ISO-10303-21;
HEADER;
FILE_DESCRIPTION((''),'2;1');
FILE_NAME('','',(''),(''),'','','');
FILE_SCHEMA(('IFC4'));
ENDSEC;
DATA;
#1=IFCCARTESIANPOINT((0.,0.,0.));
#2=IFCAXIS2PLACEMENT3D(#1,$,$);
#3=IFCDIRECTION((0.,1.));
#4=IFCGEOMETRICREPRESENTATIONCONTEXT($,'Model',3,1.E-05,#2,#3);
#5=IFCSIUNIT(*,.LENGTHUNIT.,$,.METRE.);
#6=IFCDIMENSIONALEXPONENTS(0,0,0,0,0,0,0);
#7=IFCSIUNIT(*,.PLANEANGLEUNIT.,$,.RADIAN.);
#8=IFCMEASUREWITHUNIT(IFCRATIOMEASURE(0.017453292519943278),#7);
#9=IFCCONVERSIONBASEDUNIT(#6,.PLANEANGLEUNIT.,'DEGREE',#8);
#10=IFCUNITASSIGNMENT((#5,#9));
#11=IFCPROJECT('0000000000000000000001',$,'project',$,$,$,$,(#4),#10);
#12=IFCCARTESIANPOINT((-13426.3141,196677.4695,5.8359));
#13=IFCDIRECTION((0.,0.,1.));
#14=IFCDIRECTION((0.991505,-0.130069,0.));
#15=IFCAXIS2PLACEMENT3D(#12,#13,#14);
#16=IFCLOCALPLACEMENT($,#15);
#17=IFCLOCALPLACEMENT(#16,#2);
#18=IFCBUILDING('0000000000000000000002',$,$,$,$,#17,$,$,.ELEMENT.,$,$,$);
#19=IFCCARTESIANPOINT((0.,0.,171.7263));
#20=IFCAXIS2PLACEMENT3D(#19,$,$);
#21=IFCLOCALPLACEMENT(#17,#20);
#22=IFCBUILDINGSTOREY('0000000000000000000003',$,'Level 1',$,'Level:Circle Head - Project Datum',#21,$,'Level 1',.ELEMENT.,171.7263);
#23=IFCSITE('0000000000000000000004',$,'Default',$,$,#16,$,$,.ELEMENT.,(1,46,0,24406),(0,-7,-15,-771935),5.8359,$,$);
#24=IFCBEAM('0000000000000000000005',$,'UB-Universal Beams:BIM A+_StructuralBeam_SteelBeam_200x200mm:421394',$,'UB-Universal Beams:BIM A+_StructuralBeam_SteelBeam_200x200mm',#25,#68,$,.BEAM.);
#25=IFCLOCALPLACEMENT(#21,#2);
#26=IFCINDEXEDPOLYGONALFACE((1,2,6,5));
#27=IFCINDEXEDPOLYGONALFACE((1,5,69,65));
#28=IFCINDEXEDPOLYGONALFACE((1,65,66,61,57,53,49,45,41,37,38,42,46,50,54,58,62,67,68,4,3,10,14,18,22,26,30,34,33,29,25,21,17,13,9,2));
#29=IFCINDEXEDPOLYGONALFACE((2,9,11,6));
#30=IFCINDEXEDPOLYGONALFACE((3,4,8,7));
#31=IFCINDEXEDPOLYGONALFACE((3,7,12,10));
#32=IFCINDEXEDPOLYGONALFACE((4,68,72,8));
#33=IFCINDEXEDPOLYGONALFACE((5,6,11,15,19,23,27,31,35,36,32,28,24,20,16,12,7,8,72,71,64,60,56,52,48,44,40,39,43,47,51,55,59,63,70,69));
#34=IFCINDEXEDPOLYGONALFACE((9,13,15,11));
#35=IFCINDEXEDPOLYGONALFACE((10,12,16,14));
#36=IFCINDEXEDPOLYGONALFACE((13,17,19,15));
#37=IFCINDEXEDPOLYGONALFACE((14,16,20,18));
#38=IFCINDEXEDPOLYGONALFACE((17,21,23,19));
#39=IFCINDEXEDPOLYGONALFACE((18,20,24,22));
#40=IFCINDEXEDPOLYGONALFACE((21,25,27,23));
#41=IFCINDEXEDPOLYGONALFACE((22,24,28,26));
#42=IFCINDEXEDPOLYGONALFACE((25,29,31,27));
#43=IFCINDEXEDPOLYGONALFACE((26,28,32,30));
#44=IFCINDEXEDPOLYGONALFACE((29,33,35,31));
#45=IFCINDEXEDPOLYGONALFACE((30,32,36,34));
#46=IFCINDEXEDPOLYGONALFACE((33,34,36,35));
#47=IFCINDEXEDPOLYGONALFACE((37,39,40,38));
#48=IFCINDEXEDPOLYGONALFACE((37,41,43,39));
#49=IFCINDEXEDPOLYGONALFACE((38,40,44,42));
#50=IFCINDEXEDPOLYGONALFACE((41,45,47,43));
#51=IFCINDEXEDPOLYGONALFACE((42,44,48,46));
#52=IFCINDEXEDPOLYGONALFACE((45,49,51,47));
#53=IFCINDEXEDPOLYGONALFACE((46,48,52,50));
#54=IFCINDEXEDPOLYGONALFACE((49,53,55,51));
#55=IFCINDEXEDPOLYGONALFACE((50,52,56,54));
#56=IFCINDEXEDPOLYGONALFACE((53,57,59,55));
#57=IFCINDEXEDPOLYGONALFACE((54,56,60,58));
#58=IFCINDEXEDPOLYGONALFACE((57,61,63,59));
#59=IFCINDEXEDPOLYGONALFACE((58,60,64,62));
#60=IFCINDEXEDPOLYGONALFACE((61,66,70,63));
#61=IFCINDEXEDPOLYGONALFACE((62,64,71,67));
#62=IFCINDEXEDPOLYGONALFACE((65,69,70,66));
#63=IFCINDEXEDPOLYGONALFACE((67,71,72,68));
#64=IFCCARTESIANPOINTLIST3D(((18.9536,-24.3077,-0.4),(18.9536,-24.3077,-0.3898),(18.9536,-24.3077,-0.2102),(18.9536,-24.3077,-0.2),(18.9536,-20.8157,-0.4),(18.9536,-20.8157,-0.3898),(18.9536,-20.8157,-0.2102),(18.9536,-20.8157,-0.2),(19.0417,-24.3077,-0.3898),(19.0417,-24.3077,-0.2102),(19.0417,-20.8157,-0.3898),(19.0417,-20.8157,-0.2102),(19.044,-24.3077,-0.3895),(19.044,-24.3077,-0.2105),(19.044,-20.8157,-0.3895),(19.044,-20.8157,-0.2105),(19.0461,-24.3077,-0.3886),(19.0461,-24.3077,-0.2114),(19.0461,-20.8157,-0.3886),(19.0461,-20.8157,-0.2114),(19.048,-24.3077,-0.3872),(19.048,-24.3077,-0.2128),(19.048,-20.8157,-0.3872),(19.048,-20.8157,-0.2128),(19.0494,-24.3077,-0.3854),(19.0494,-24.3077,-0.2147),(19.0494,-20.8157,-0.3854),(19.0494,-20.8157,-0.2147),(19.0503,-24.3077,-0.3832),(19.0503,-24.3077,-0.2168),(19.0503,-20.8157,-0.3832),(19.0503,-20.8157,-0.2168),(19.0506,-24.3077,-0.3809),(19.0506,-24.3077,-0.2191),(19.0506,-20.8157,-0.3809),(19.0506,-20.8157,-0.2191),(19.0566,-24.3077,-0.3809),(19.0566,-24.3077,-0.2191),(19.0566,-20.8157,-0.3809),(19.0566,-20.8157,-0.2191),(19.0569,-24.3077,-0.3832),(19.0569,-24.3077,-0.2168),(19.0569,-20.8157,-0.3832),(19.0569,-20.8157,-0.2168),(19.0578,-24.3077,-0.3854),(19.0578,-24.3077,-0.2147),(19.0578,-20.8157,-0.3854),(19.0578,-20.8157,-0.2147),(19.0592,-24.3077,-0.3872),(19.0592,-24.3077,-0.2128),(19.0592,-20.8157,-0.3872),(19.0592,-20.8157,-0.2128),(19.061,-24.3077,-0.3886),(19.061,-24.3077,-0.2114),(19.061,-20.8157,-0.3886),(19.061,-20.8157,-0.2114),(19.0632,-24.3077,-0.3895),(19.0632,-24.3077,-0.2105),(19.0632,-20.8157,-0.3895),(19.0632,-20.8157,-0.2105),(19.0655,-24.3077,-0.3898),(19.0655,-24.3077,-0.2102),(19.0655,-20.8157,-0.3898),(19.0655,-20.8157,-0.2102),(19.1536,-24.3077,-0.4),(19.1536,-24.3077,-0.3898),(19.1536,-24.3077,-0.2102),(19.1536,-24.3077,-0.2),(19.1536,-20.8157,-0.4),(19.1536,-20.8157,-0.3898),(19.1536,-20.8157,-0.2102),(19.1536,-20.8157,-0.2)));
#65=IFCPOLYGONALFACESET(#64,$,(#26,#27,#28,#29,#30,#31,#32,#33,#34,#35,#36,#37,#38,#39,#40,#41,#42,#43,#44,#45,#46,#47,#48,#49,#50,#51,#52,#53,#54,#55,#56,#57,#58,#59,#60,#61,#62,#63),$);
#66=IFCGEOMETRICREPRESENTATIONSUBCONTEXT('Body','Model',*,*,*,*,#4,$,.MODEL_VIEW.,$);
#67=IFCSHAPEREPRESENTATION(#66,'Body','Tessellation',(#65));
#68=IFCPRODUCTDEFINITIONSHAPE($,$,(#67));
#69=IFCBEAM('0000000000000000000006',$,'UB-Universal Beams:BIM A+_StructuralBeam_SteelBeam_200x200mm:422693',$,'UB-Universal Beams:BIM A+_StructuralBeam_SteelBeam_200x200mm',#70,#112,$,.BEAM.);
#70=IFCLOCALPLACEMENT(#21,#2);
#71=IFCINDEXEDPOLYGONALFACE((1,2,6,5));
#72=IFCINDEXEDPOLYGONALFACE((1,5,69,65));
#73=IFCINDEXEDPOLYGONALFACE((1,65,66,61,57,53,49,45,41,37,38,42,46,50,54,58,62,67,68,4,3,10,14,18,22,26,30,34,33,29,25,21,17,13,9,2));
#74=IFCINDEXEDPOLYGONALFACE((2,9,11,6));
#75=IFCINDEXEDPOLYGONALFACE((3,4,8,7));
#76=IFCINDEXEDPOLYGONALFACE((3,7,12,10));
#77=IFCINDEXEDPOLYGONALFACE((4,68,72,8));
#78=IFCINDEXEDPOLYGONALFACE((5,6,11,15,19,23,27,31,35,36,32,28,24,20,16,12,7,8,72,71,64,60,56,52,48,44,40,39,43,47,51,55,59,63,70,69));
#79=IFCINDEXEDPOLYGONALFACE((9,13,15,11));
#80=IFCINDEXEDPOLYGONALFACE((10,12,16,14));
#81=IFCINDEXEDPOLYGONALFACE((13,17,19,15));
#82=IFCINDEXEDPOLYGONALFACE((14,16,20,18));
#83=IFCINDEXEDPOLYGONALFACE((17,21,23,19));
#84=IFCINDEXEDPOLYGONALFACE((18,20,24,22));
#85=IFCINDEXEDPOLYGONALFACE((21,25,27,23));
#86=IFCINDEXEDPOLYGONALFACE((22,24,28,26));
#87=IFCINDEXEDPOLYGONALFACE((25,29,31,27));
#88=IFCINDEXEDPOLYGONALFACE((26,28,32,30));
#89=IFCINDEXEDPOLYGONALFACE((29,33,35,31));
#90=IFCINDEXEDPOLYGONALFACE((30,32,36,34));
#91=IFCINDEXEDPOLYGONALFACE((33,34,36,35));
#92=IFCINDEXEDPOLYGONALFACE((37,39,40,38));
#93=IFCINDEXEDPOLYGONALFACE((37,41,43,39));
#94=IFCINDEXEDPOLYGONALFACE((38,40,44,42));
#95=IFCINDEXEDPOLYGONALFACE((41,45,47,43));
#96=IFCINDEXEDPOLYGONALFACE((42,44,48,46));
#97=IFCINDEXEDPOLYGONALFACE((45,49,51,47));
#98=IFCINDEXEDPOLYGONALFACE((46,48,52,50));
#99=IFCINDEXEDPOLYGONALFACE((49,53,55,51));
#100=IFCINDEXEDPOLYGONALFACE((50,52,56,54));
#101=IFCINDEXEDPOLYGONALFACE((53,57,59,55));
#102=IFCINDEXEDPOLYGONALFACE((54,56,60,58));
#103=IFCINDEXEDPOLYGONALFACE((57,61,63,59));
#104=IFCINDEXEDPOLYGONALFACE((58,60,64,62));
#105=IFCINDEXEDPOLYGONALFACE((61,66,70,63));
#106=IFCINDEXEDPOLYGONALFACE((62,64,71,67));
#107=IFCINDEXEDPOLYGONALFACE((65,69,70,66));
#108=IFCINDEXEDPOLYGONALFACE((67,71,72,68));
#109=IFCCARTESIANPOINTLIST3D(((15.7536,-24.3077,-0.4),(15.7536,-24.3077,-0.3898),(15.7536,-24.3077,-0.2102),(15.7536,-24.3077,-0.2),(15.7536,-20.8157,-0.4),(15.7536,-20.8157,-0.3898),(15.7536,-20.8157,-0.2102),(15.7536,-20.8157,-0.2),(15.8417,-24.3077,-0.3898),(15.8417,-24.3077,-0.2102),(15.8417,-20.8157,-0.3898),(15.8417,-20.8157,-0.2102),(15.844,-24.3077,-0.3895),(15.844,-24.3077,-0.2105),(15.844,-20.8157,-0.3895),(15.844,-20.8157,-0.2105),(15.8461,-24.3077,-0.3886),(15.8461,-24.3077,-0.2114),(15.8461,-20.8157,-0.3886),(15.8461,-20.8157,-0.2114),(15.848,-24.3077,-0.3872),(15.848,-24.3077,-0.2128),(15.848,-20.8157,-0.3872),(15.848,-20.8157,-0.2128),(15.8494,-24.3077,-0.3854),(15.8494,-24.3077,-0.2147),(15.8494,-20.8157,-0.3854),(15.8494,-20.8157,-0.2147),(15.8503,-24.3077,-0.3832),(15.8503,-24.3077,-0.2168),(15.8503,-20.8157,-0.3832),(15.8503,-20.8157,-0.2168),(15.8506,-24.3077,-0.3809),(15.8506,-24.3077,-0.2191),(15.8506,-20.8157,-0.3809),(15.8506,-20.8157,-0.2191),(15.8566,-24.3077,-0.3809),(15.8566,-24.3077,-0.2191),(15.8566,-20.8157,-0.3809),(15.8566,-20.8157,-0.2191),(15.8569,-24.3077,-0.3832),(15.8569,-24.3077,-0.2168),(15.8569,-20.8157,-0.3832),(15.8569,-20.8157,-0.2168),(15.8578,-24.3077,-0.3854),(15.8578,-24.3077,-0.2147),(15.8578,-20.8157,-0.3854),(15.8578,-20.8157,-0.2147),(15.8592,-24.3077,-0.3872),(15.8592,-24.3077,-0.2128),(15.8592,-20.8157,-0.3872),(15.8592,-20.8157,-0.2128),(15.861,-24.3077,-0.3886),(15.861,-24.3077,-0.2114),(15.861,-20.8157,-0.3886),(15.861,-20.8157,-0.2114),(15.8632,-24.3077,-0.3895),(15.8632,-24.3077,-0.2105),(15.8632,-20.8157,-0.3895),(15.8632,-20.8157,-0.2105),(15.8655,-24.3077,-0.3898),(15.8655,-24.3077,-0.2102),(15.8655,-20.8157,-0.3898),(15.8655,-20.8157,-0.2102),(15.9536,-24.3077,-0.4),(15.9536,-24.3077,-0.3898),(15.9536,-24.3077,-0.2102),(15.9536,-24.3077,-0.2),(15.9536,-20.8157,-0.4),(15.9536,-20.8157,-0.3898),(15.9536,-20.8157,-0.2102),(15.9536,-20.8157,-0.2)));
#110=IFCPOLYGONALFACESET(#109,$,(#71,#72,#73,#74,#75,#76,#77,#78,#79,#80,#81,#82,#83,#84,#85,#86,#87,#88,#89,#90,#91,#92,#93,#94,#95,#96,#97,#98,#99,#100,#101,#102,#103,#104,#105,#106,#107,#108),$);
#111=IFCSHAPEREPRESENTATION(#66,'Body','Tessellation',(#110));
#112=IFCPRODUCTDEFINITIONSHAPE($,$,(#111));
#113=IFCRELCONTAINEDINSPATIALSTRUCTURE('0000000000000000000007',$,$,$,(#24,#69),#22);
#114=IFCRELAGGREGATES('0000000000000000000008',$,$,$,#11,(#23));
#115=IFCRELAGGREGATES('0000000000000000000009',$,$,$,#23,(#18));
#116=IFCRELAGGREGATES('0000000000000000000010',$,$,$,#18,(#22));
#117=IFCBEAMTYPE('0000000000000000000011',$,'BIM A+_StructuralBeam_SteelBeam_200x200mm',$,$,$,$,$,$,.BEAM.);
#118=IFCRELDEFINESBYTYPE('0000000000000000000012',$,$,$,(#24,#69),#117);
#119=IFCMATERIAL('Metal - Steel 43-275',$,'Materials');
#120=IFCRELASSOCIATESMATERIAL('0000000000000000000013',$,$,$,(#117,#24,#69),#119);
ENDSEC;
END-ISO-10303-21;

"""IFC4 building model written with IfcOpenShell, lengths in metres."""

from ifc_helpers import new_model, entity, si_unit, converted_unit, direction, frame, origin, place, context, subcontext, project, spatial, line, arc, indexed_curve, outline, extrude, source, transform, mapped, material, type_object, type_shapes, element, save


model = new_model("IFC4")

# Units and contexts
model_context = context("Model", 3, precision=1e-05, world=origin(), true_north=direction((0.0, 1.0)))
body_context = subcontext(model_context, "Body", "Model", "MODEL_VIEW")
ifc_project = project(units=[si_unit("LENGTHUNIT", "METRE"), converted_unit("PLANEANGLEUNIT", "DEGREE", entity("IfcRatioMeasure", 0.017453292519943278), si_unit("PLANEANGLEUNIT", "RADIAN"), dimensions=[0, 0, 0, 0, 0, 0, 0])], contexts=[model_context])

# Site, building, storey
site_placement = place(None, frame((-13426.3141, 196677.4695, 5.8359), z_axis=(0.0, 0.0, 1.0), x_axis=(0.991505, -0.130069, 0.0)))
site = spatial("IfcSite", under=ifc_project, at=site_placement, Name="Default", CompositionType="ELEMENT", RefLatitude=(1, 46, 0, 24406), RefLongitude=(0, -7, -15, -771935), RefElevation=5.8359)
building_placement = place(site_placement, origin())
building = spatial("IfcBuilding", under=site, at=building_placement, CompositionType="ELEMENT")
storey_placement = place(building_placement, frame((0.0, 0.0, 171.7263)))
storey = spatial("IfcBuildingStorey", under=building, at=storey_placement, Name="Level 1", ObjectType="Level:Circle Head - Project Datum", LongName="Level 1", CompositionType="ELEMENT", Elevation=171.7263)

# Shared definitions
ifc_material_1 = material(Name="Metal - Steel 43-275", Category="Materials")

# Beams
beam_type_1 = type_object("IfcBeamType", Name="BIM A+_StructuralBeam_SteelBeam_200x200mm", PredefinedType="BEAM", material=ifc_material_1)
shared_shape_1 = source(origin(), body_context, "Body", "SweptSolid", [
    extrude(outline(indexed_curve([(-0.1, -0.1), (-0.0898, -0.1), (-0.0898, -0.0119), (-0.0872, -0.0056), (-0.0809, -0.003), (0.0809, -0.003), (0.0872, -0.0056), (0.0898, -0.0119), (0.0898, -0.1), (0.1, -0.1), (0.1, 0.1), (0.0898, 0.1), (0.0898, 0.0119), (0.0872, 0.0056), (0.0809, 0.003), (-0.0809, 0.003), (-0.0872, 0.0056), (-0.0898, 0.0119), (-0.0898, 0.1), (-0.1, 0.1)], segments=[line(1, 2, 3), arc(3, 4, 5), line(5, 6), arc(6, 7, 8), line(8, 9, 10, 11, 12, 13), arc(13, 14, 15), line(15, 16), arc(16, 17, 18), line(18, 19, 20, 1)], self_intersect=False)), frame((1.0024, 0.0, 0.0), z_axis=(1.0, 0.0, 0.0), x_axis=(0.0, 0.0, -1.0)), (0.0, 0.0, 1.0), 3.492),
])
type_shapes(beam_type_1, [shared_shape_1])
for number, where, z_axis, x_axis, name in (
    (1, (19.0536, -19.8132, -0.3), (0.0, 0.0, 1.0), (0.0, -1.0, 0.0), "UB-Universal Beams:BIM A+_StructuralBeam_SteelBeam_200x200mm:421394"),
    (2, (15.8536, -19.8132, -0.3), (0.0, 0.0, 1.0), (0.0, -1.0, 0.0), "UB-Universal Beams:BIM A+_StructuralBeam_SteelBeam_200x200mm:422693"),
):
    element("IfcBeam", number, at=place(storey_placement, frame(where, z_axis=z_axis, x_axis=x_axis)), inside=storey, type_object=beam_type_1, material=ifc_material_1, Name=name, ObjectType="UB-Universal Beams:BIM A+_StructuralBeam_SteelBeam_200x200mm", PredefinedType="BEAM", context=body_context, shape_type="MappedRepresentation", body=[
        mapped(shared_shape_1, transform((0.0, 0.0, 0.0), scale=1.0)),
    ])

save(model, "model.ifc")
